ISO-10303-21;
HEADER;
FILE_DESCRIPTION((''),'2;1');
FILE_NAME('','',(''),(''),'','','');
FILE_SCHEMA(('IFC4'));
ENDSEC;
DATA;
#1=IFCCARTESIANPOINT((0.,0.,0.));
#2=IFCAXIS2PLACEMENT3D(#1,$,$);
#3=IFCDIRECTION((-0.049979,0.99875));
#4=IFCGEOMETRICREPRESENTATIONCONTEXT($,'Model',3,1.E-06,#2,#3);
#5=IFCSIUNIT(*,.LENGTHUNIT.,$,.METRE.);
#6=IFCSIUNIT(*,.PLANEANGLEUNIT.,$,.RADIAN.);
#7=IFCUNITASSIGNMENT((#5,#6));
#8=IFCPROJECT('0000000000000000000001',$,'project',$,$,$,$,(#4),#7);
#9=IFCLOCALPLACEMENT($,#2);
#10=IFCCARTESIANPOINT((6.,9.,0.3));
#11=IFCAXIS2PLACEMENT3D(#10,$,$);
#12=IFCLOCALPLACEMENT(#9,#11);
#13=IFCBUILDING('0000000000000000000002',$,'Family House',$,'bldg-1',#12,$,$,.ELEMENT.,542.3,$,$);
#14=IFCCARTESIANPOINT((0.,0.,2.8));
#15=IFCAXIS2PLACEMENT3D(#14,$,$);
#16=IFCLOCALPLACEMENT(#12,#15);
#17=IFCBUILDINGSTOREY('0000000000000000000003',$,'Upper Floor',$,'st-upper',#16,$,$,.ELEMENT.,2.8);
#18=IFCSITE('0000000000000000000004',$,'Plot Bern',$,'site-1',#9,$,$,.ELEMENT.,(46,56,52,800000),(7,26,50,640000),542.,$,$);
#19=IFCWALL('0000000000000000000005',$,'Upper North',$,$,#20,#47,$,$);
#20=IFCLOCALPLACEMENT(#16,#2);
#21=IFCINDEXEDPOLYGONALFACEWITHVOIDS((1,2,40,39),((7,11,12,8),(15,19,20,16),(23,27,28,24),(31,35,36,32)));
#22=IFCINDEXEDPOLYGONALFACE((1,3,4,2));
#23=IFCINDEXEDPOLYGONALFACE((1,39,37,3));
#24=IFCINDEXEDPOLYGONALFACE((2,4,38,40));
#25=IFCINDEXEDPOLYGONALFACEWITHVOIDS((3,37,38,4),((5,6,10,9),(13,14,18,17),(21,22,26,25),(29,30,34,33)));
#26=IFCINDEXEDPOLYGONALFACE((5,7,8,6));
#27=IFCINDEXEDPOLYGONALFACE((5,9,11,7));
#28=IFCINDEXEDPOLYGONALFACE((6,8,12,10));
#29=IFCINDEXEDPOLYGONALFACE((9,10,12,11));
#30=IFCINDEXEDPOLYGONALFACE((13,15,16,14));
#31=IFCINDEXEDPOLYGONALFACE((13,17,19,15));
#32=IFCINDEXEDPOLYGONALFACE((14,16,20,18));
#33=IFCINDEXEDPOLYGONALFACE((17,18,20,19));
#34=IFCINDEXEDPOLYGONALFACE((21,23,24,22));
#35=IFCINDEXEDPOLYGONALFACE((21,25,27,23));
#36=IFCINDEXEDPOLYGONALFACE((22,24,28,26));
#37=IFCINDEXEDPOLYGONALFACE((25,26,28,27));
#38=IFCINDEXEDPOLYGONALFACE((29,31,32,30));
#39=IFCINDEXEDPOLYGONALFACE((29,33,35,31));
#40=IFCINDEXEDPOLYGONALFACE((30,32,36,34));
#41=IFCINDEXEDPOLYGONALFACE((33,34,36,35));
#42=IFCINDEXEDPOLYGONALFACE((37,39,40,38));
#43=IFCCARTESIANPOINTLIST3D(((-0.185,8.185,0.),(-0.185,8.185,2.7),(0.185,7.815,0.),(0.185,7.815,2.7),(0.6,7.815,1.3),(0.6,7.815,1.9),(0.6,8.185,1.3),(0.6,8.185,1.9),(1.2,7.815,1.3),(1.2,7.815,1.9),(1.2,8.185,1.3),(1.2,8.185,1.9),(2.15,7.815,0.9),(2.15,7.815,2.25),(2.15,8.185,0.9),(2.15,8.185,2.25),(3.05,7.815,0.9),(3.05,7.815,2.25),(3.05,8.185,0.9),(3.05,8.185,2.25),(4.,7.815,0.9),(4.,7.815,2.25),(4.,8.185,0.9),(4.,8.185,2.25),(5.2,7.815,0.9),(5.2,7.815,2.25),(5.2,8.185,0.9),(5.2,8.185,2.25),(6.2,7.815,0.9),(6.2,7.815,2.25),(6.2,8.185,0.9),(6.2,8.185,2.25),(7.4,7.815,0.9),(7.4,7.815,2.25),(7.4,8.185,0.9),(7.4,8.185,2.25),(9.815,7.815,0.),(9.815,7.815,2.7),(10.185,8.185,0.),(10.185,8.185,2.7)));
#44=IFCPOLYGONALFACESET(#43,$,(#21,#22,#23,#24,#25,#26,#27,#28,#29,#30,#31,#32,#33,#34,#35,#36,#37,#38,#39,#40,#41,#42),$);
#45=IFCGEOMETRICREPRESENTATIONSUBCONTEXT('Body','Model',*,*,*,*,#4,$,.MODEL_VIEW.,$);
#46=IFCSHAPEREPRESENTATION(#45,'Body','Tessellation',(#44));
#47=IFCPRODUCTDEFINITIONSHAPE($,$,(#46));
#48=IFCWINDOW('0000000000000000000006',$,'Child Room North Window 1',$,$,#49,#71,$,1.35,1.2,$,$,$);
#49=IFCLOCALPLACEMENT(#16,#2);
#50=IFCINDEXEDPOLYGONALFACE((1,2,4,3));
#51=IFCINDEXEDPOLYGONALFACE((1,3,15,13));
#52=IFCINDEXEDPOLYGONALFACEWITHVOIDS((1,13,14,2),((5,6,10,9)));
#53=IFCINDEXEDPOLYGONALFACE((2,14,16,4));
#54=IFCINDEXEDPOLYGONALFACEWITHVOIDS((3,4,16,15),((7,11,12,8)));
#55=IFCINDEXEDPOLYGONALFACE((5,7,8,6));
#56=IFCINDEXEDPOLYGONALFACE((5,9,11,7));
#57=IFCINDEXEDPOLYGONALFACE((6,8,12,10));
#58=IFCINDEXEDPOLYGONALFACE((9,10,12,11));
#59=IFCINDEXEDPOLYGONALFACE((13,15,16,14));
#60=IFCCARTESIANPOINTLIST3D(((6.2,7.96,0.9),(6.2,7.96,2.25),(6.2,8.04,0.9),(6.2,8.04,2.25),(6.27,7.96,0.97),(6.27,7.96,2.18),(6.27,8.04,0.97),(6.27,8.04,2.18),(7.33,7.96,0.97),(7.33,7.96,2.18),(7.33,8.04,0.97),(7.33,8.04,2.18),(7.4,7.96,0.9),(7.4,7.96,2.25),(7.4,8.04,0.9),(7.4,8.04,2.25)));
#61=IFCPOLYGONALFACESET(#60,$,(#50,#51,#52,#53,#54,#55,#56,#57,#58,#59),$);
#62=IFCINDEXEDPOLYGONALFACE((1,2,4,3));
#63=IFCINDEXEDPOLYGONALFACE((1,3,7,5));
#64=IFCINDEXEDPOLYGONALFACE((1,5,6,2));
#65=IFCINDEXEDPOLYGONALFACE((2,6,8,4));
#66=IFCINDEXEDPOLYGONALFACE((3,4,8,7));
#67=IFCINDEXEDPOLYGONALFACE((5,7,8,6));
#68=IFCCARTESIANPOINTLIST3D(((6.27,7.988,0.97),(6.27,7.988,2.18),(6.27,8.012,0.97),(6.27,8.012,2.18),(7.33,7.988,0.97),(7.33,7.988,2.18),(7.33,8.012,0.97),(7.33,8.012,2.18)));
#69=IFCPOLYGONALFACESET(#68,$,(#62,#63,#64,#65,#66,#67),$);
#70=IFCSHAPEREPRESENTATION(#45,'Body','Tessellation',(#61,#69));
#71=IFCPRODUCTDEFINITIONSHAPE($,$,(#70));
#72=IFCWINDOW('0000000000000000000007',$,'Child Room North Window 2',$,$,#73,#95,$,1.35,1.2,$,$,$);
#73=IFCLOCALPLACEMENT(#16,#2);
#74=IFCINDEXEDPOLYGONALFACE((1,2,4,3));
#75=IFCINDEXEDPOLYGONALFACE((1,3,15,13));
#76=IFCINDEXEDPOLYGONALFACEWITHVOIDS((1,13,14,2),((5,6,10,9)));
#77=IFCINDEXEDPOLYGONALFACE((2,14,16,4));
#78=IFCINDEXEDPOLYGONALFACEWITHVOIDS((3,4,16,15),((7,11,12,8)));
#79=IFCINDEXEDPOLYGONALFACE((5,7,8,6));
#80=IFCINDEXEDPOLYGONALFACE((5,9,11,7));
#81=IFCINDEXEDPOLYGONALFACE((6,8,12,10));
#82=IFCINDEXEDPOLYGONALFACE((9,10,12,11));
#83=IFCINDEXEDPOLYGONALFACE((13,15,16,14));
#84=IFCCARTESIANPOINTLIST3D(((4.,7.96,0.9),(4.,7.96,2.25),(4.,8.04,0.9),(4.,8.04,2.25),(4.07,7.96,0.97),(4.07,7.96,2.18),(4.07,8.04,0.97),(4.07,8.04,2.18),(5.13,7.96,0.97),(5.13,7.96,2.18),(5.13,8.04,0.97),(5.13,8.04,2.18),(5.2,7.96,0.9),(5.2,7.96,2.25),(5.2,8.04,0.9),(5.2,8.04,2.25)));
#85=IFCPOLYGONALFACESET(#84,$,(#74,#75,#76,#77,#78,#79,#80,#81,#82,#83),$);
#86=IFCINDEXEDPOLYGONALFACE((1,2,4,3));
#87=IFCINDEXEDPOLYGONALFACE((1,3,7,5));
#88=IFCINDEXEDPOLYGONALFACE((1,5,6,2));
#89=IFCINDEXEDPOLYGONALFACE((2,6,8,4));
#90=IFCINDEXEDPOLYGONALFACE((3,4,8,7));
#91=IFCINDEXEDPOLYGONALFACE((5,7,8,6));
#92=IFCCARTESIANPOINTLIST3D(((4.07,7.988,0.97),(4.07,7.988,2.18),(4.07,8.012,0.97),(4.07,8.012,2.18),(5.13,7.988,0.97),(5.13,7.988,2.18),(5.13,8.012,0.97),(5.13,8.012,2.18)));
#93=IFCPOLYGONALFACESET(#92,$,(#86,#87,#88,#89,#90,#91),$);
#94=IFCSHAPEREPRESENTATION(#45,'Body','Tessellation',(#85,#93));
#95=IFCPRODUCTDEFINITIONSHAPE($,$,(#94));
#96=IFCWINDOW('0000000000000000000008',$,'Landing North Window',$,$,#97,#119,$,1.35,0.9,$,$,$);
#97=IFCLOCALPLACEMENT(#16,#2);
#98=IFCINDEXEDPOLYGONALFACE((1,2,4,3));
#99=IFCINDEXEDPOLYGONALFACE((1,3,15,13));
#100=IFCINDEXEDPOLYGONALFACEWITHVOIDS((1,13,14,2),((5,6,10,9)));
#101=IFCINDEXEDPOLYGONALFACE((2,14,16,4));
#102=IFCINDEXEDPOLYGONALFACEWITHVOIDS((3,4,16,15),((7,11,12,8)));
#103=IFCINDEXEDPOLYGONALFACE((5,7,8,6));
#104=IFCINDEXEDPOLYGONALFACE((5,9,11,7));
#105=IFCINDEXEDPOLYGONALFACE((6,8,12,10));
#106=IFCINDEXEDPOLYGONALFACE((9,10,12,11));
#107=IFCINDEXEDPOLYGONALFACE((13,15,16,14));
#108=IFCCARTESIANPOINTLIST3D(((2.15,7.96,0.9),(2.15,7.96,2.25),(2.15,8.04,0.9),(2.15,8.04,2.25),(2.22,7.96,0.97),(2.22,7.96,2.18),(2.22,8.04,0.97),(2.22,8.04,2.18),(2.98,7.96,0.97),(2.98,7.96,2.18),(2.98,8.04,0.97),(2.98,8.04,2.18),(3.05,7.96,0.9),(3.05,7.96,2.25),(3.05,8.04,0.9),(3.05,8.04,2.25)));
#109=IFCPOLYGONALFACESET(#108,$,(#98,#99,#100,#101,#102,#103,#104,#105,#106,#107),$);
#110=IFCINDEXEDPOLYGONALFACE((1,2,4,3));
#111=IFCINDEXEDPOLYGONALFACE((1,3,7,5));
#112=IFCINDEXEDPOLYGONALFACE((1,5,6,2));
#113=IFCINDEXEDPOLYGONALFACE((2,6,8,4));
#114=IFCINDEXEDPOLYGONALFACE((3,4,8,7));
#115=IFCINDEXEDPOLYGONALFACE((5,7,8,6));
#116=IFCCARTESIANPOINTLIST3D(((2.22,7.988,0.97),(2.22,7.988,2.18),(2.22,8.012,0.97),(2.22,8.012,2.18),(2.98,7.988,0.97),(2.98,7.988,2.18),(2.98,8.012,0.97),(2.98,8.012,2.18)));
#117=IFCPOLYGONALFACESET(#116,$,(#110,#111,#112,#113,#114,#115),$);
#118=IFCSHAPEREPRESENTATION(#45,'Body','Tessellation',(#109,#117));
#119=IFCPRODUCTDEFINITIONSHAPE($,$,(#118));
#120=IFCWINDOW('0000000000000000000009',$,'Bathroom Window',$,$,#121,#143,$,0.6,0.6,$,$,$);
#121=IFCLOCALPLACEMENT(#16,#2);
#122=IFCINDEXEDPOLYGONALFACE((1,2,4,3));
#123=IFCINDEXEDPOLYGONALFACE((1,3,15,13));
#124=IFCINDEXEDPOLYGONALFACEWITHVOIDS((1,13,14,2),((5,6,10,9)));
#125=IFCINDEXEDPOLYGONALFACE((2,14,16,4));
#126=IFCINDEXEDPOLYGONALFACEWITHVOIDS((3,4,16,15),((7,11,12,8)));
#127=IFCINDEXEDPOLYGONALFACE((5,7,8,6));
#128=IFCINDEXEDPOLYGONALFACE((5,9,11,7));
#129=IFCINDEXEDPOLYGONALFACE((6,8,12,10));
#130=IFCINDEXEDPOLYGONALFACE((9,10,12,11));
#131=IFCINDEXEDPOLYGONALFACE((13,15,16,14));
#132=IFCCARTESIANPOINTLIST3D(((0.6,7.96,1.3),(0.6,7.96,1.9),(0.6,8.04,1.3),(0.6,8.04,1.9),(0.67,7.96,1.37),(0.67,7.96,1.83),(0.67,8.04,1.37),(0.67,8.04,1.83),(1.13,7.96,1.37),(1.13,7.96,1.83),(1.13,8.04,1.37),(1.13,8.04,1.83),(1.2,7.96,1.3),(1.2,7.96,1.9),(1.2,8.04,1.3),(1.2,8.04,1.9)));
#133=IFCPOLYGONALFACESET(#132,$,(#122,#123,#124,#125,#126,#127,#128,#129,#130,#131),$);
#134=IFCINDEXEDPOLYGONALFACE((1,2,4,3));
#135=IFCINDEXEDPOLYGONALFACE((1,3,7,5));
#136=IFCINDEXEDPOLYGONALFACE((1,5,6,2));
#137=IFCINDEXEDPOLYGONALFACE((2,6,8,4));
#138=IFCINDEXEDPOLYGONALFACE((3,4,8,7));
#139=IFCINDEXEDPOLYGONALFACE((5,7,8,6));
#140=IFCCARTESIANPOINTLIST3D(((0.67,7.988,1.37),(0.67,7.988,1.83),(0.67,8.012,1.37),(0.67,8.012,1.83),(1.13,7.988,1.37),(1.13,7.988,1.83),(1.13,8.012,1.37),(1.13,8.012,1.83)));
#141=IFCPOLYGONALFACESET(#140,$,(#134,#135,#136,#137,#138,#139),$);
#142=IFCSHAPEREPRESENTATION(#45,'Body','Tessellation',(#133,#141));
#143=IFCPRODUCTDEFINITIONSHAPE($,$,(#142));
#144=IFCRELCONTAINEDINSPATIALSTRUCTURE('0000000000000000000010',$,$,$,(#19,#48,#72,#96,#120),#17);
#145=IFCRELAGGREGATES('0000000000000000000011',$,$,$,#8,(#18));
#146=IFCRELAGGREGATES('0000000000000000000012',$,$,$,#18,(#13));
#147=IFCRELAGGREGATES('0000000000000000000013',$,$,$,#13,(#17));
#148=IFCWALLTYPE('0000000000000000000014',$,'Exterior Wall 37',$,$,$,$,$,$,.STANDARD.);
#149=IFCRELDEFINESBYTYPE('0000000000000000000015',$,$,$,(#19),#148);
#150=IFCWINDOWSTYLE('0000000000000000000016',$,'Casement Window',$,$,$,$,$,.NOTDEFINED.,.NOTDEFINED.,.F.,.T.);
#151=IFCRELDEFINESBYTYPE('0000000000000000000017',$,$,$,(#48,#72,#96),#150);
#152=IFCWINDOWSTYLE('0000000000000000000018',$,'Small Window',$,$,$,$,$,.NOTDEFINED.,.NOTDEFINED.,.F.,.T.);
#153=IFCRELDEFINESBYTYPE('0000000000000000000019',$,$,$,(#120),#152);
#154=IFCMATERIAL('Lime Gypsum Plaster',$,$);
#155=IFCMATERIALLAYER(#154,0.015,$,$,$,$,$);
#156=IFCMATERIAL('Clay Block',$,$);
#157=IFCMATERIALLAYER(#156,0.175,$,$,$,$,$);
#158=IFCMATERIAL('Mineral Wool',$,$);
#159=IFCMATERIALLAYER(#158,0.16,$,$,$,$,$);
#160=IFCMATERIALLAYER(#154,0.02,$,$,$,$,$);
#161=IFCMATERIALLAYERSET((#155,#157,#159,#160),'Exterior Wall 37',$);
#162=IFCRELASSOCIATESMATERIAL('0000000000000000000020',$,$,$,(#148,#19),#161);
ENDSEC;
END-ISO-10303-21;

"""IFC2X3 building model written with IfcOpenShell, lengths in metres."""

from ifc_helpers import new_model, si_unit, direction, frame, frame_2d, origin, origin_2d, place, context, subcontext, project, spatial, polyline, rectangle, outline, extrude, material, layer, layer_set, layer_usage, type_object, element, fill, save


model = new_model("IFC2X3")

# Units and contexts
model_context = context("Model", 3, precision=1e-06, world=origin(), true_north=direction((-0.049979, 0.99875)))
body_context = subcontext(model_context, "Body", "Model", "MODEL_VIEW")
ifc_project = project(units=[si_unit("LENGTHUNIT", "METRE"), si_unit("PLANEANGLEUNIT", "RADIAN")], contexts=[model_context])

# Site, building, storey
site_placement = place(None, origin())
site = spatial("IfcSite", under=ifc_project, at=site_placement, Name="Plot Bern", ObjectType="site-1", CompositionType="ELEMENT", RefLatitude=(46, 56, 52, 800000), RefLongitude=(7, 26, 50, 640000), RefElevation=542.0)
building_placement = place(site_placement, frame((6.0, 9.0, 0.3)))
building = spatial("IfcBuilding", under=site, at=building_placement, Name="Family House", ObjectType="bldg-1", CompositionType="ELEMENT", ElevationOfRefHeight=542.3)
storey_placement = place(building_placement, frame((0.0, 0.0, 2.8)))
storey = spatial("IfcBuildingStorey", under=building, at=storey_placement, Name="Upper Floor", ObjectType="st-upper", CompositionType="ELEMENT", Elevation=2.8)

# Shared definitions
ifc_material_1 = material(Name="Mineral Wool")

# Shared definitions
ifc_material_2 = material(Name="Lime Gypsum Plaster")
ifc_layer_1 = layer(ifc_material_2, 0.015)
ifc_material_3 = material(Name="Clay Block")
ifc_layer_2 = layer(ifc_material_3, 0.175)
ifc_layer_3 = layer(ifc_material_1, 0.16)
ifc_layer_4 = layer(ifc_material_2, 0.02)
ifc_layer_set_1 = layer_set([ifc_layer_1, ifc_layer_2, ifc_layer_3, ifc_layer_4], Name="Exterior Wall 37")
wall_type_1 = type_object("IfcWallType", Name="Exterior Wall 37", PredefinedType="STANDARD", material=ifc_layer_set_1)

# Shared definitions
window_style_1 = type_object("IfcWindowStyle", Name="Casement Window", ConstructionType="NOTDEFINED", OperationType="NOTDEFINED", ParameterTakesPrecedence=False, Sizeable=True)

# Wall, openings, windows
ifc_layer_usage_1 = layer_usage(ifc_layer_set_1, "AXIS2", "NEGATIVE", 0.185)
wall_1_placement = place(storey_placement, origin())
wall_1 = element("IfcWall", 1, at=wall_1_placement, inside=storey, type_object=wall_type_1, material=ifc_layer_usage_1, Name="Upper North", context=body_context, shape_type="SweptSolid", body=[
    extrude(outline(polyline([(10.185, 8.185), (-0.185, 8.185), (0.185, 7.815), (9.815, 7.815), (10.185, 8.185)])), origin(), (0.0, 0.0, 1.0), 2.7),
])
opening_1_placement = place(wall_1_placement, frame((0.9, 8.0, 1.3), z_axis=(0.0, 0.0, 1.0), x_axis=(-1.0, 0.0, 0.0)))
opening_1 = element("IfcOpeningElement", 2, at=opening_1_placement, cuts=wall_1, context=body_context, shape_type="SweptSolid", body=[
    extrude(rectangle(XDim=0.6, YDim=0.37, at=origin_2d()), origin(), (0.0, 0.0, 1.0), 0.6),
])
opening_2_placement = place(wall_1_placement, frame((6.8, 8.0, 0.9), z_axis=(0.0, 0.0, 1.0), x_axis=(-1.0, 0.0, 0.0)))
opening_2 = element("IfcOpeningElement", 3, at=opening_2_placement, cuts=wall_1, context=body_context, shape_type="SweptSolid", body=[
    extrude(rectangle(XDim=1.2, YDim=0.37, at=origin_2d()), origin(), (0.0, 0.0, 1.0), 1.35),
])
opening_3_placement = place(wall_1_placement, frame((4.6, 8.0, 0.9), z_axis=(0.0, 0.0, 1.0), x_axis=(-1.0, 0.0, 0.0)))
opening_3 = element("IfcOpeningElement", 4, at=opening_3_placement, cuts=wall_1, context=body_context, shape_type="SweptSolid", body=[
    extrude(rectangle(XDim=1.2, YDim=0.37, at=origin_2d()), origin(), (0.0, 0.0, 1.0), 1.35),
])
opening_4_placement = place(wall_1_placement, frame((2.6, 8.0, 0.9), z_axis=(0.0, 0.0, 1.0), x_axis=(-1.0, 0.0, 0.0)))
opening_4 = element("IfcOpeningElement", 5, at=opening_4_placement, cuts=wall_1, context=body_context, shape_type="SweptSolid", body=[
    extrude(rectangle(XDim=0.9, YDim=0.37, at=origin_2d()), origin(), (0.0, 0.0, 1.0), 1.35),
])
window_1_placement = place(opening_2_placement, frame((0.0, 0.0, 0.0), z_axis=(0.0, -1.0, 0.0), x_axis=(1.0, 0.0, 0.0)))
window_1 = element("IfcWindow", 6, at=window_1_placement, inside=storey, type_object=window_style_1, Name="Child Room North Window 1", OverallHeight=1.35, OverallWidth=1.2, context=body_context, shape_type="SweptSolid", body=[
    extrude(outline(polyline([(-0.6, 0.0), (0.6, 0.0), (0.6, 1.35), (-0.6, 1.35), (-0.6, 0.0)]), holes=[polyline([(-0.53, 0.07), (0.53, 0.07), (0.53, 1.28), (-0.53, 1.28), (-0.53, 0.07)])]), frame((0.0, 0.0, -0.04)), (0.0, 0.0, 1.0), 0.08),
    extrude(rectangle(XDim=1.06, YDim=1.21, at=frame_2d((0.0, 0.675))), frame((0.0, 0.0, -0.012)), (0.0, 0.0, 1.0), 0.024),
])
fill(opening_2, window_1)
window_2_placement = place(opening_3_placement, frame((0.0, 0.0, 0.0), z_axis=(0.0, -1.0, 0.0), x_axis=(1.0, 0.0, 0.0)))
window_2 = element("IfcWindow", 7, at=window_2_placement, inside=storey, type_object=window_style_1, Name="Child Room North Window 2", OverallHeight=1.35, OverallWidth=1.2, context=body_context, shape_type="SweptSolid", body=[
    extrude(outline(polyline([(-0.6, 0.0), (0.6, 0.0), (0.6, 1.35), (-0.6, 1.35), (-0.6, 0.0)]), holes=[polyline([(-0.53, 0.07), (0.53, 0.07), (0.53, 1.28), (-0.53, 1.28), (-0.53, 0.07)])]), frame((0.0, 0.0, -0.04)), (0.0, 0.0, 1.0), 0.08),
    extrude(rectangle(XDim=1.06, YDim=1.21, at=frame_2d((0.0, 0.675))), frame((0.0, 0.0, -0.012)), (0.0, 0.0, 1.0), 0.024),
])
fill(opening_3, window_2)
window_3_placement = place(opening_4_placement, frame((0.0, 0.0, 0.0), z_axis=(0.0, -1.0, 0.0), x_axis=(1.0, 0.0, 0.0)))
window_3 = element("IfcWindow", 8, at=window_3_placement, inside=storey, type_object=window_style_1, Name="Landing North Window", OverallHeight=1.35, OverallWidth=0.9, context=body_context, shape_type="SweptSolid", body=[
    extrude(outline(polyline([(-0.45, 0.0), (0.45, 0.0), (0.45, 1.35), (-0.45, 1.35), (-0.45, 0.0)]), holes=[polyline([(-0.38, 0.07), (0.38, 0.07), (0.38, 1.28), (-0.38, 1.28), (-0.38, 0.07)])]), frame((0.0, 0.0, -0.04)), (0.0, 0.0, 1.0), 0.08),
    extrude(rectangle(XDim=0.76, YDim=1.21, at=frame_2d((0.0, 0.675))), frame((0.0, 0.0, -0.012)), (0.0, 0.0, 1.0), 0.024),
])
fill(opening_4, window_3)
window_style_2 = type_object("IfcWindowStyle", Name="Small Window", ConstructionType="NOTDEFINED", OperationType="NOTDEFINED", ParameterTakesPrecedence=False, Sizeable=True)
window_4_placement = place(opening_1_placement, frame((0.0, 0.0, 0.0), z_axis=(0.0, -1.0, 0.0), x_axis=(1.0, 0.0, 0.0)))
window_4 = element("IfcWindow", 9, at=window_4_placement, inside=storey, type_object=window_style_2, Name="Bathroom Window", OverallHeight=0.6, OverallWidth=0.6, context=body_context, shape_type="SweptSolid", body=[
    extrude(outline(polyline([(-0.3, 0.0), (0.3, 0.0), (0.3, 0.6), (-0.3, 0.6), (-0.3, 0.0)]), holes=[polyline([(-0.23, 0.07), (0.23, 0.07), (0.23, 0.53), (-0.23, 0.53), (-0.23, 0.07)])]), frame((0.0, 0.0, -0.04)), (0.0, 0.0, 1.0), 0.08),
    extrude(rectangle(XDim=0.46, YDim=0.46, at=frame_2d((0.0, 0.3))), frame((0.0, 0.0, -0.012)), (0.0, 0.0, 1.0), 0.024),
])
fill(opening_1, window_4)

save(model, "model.ifc")
